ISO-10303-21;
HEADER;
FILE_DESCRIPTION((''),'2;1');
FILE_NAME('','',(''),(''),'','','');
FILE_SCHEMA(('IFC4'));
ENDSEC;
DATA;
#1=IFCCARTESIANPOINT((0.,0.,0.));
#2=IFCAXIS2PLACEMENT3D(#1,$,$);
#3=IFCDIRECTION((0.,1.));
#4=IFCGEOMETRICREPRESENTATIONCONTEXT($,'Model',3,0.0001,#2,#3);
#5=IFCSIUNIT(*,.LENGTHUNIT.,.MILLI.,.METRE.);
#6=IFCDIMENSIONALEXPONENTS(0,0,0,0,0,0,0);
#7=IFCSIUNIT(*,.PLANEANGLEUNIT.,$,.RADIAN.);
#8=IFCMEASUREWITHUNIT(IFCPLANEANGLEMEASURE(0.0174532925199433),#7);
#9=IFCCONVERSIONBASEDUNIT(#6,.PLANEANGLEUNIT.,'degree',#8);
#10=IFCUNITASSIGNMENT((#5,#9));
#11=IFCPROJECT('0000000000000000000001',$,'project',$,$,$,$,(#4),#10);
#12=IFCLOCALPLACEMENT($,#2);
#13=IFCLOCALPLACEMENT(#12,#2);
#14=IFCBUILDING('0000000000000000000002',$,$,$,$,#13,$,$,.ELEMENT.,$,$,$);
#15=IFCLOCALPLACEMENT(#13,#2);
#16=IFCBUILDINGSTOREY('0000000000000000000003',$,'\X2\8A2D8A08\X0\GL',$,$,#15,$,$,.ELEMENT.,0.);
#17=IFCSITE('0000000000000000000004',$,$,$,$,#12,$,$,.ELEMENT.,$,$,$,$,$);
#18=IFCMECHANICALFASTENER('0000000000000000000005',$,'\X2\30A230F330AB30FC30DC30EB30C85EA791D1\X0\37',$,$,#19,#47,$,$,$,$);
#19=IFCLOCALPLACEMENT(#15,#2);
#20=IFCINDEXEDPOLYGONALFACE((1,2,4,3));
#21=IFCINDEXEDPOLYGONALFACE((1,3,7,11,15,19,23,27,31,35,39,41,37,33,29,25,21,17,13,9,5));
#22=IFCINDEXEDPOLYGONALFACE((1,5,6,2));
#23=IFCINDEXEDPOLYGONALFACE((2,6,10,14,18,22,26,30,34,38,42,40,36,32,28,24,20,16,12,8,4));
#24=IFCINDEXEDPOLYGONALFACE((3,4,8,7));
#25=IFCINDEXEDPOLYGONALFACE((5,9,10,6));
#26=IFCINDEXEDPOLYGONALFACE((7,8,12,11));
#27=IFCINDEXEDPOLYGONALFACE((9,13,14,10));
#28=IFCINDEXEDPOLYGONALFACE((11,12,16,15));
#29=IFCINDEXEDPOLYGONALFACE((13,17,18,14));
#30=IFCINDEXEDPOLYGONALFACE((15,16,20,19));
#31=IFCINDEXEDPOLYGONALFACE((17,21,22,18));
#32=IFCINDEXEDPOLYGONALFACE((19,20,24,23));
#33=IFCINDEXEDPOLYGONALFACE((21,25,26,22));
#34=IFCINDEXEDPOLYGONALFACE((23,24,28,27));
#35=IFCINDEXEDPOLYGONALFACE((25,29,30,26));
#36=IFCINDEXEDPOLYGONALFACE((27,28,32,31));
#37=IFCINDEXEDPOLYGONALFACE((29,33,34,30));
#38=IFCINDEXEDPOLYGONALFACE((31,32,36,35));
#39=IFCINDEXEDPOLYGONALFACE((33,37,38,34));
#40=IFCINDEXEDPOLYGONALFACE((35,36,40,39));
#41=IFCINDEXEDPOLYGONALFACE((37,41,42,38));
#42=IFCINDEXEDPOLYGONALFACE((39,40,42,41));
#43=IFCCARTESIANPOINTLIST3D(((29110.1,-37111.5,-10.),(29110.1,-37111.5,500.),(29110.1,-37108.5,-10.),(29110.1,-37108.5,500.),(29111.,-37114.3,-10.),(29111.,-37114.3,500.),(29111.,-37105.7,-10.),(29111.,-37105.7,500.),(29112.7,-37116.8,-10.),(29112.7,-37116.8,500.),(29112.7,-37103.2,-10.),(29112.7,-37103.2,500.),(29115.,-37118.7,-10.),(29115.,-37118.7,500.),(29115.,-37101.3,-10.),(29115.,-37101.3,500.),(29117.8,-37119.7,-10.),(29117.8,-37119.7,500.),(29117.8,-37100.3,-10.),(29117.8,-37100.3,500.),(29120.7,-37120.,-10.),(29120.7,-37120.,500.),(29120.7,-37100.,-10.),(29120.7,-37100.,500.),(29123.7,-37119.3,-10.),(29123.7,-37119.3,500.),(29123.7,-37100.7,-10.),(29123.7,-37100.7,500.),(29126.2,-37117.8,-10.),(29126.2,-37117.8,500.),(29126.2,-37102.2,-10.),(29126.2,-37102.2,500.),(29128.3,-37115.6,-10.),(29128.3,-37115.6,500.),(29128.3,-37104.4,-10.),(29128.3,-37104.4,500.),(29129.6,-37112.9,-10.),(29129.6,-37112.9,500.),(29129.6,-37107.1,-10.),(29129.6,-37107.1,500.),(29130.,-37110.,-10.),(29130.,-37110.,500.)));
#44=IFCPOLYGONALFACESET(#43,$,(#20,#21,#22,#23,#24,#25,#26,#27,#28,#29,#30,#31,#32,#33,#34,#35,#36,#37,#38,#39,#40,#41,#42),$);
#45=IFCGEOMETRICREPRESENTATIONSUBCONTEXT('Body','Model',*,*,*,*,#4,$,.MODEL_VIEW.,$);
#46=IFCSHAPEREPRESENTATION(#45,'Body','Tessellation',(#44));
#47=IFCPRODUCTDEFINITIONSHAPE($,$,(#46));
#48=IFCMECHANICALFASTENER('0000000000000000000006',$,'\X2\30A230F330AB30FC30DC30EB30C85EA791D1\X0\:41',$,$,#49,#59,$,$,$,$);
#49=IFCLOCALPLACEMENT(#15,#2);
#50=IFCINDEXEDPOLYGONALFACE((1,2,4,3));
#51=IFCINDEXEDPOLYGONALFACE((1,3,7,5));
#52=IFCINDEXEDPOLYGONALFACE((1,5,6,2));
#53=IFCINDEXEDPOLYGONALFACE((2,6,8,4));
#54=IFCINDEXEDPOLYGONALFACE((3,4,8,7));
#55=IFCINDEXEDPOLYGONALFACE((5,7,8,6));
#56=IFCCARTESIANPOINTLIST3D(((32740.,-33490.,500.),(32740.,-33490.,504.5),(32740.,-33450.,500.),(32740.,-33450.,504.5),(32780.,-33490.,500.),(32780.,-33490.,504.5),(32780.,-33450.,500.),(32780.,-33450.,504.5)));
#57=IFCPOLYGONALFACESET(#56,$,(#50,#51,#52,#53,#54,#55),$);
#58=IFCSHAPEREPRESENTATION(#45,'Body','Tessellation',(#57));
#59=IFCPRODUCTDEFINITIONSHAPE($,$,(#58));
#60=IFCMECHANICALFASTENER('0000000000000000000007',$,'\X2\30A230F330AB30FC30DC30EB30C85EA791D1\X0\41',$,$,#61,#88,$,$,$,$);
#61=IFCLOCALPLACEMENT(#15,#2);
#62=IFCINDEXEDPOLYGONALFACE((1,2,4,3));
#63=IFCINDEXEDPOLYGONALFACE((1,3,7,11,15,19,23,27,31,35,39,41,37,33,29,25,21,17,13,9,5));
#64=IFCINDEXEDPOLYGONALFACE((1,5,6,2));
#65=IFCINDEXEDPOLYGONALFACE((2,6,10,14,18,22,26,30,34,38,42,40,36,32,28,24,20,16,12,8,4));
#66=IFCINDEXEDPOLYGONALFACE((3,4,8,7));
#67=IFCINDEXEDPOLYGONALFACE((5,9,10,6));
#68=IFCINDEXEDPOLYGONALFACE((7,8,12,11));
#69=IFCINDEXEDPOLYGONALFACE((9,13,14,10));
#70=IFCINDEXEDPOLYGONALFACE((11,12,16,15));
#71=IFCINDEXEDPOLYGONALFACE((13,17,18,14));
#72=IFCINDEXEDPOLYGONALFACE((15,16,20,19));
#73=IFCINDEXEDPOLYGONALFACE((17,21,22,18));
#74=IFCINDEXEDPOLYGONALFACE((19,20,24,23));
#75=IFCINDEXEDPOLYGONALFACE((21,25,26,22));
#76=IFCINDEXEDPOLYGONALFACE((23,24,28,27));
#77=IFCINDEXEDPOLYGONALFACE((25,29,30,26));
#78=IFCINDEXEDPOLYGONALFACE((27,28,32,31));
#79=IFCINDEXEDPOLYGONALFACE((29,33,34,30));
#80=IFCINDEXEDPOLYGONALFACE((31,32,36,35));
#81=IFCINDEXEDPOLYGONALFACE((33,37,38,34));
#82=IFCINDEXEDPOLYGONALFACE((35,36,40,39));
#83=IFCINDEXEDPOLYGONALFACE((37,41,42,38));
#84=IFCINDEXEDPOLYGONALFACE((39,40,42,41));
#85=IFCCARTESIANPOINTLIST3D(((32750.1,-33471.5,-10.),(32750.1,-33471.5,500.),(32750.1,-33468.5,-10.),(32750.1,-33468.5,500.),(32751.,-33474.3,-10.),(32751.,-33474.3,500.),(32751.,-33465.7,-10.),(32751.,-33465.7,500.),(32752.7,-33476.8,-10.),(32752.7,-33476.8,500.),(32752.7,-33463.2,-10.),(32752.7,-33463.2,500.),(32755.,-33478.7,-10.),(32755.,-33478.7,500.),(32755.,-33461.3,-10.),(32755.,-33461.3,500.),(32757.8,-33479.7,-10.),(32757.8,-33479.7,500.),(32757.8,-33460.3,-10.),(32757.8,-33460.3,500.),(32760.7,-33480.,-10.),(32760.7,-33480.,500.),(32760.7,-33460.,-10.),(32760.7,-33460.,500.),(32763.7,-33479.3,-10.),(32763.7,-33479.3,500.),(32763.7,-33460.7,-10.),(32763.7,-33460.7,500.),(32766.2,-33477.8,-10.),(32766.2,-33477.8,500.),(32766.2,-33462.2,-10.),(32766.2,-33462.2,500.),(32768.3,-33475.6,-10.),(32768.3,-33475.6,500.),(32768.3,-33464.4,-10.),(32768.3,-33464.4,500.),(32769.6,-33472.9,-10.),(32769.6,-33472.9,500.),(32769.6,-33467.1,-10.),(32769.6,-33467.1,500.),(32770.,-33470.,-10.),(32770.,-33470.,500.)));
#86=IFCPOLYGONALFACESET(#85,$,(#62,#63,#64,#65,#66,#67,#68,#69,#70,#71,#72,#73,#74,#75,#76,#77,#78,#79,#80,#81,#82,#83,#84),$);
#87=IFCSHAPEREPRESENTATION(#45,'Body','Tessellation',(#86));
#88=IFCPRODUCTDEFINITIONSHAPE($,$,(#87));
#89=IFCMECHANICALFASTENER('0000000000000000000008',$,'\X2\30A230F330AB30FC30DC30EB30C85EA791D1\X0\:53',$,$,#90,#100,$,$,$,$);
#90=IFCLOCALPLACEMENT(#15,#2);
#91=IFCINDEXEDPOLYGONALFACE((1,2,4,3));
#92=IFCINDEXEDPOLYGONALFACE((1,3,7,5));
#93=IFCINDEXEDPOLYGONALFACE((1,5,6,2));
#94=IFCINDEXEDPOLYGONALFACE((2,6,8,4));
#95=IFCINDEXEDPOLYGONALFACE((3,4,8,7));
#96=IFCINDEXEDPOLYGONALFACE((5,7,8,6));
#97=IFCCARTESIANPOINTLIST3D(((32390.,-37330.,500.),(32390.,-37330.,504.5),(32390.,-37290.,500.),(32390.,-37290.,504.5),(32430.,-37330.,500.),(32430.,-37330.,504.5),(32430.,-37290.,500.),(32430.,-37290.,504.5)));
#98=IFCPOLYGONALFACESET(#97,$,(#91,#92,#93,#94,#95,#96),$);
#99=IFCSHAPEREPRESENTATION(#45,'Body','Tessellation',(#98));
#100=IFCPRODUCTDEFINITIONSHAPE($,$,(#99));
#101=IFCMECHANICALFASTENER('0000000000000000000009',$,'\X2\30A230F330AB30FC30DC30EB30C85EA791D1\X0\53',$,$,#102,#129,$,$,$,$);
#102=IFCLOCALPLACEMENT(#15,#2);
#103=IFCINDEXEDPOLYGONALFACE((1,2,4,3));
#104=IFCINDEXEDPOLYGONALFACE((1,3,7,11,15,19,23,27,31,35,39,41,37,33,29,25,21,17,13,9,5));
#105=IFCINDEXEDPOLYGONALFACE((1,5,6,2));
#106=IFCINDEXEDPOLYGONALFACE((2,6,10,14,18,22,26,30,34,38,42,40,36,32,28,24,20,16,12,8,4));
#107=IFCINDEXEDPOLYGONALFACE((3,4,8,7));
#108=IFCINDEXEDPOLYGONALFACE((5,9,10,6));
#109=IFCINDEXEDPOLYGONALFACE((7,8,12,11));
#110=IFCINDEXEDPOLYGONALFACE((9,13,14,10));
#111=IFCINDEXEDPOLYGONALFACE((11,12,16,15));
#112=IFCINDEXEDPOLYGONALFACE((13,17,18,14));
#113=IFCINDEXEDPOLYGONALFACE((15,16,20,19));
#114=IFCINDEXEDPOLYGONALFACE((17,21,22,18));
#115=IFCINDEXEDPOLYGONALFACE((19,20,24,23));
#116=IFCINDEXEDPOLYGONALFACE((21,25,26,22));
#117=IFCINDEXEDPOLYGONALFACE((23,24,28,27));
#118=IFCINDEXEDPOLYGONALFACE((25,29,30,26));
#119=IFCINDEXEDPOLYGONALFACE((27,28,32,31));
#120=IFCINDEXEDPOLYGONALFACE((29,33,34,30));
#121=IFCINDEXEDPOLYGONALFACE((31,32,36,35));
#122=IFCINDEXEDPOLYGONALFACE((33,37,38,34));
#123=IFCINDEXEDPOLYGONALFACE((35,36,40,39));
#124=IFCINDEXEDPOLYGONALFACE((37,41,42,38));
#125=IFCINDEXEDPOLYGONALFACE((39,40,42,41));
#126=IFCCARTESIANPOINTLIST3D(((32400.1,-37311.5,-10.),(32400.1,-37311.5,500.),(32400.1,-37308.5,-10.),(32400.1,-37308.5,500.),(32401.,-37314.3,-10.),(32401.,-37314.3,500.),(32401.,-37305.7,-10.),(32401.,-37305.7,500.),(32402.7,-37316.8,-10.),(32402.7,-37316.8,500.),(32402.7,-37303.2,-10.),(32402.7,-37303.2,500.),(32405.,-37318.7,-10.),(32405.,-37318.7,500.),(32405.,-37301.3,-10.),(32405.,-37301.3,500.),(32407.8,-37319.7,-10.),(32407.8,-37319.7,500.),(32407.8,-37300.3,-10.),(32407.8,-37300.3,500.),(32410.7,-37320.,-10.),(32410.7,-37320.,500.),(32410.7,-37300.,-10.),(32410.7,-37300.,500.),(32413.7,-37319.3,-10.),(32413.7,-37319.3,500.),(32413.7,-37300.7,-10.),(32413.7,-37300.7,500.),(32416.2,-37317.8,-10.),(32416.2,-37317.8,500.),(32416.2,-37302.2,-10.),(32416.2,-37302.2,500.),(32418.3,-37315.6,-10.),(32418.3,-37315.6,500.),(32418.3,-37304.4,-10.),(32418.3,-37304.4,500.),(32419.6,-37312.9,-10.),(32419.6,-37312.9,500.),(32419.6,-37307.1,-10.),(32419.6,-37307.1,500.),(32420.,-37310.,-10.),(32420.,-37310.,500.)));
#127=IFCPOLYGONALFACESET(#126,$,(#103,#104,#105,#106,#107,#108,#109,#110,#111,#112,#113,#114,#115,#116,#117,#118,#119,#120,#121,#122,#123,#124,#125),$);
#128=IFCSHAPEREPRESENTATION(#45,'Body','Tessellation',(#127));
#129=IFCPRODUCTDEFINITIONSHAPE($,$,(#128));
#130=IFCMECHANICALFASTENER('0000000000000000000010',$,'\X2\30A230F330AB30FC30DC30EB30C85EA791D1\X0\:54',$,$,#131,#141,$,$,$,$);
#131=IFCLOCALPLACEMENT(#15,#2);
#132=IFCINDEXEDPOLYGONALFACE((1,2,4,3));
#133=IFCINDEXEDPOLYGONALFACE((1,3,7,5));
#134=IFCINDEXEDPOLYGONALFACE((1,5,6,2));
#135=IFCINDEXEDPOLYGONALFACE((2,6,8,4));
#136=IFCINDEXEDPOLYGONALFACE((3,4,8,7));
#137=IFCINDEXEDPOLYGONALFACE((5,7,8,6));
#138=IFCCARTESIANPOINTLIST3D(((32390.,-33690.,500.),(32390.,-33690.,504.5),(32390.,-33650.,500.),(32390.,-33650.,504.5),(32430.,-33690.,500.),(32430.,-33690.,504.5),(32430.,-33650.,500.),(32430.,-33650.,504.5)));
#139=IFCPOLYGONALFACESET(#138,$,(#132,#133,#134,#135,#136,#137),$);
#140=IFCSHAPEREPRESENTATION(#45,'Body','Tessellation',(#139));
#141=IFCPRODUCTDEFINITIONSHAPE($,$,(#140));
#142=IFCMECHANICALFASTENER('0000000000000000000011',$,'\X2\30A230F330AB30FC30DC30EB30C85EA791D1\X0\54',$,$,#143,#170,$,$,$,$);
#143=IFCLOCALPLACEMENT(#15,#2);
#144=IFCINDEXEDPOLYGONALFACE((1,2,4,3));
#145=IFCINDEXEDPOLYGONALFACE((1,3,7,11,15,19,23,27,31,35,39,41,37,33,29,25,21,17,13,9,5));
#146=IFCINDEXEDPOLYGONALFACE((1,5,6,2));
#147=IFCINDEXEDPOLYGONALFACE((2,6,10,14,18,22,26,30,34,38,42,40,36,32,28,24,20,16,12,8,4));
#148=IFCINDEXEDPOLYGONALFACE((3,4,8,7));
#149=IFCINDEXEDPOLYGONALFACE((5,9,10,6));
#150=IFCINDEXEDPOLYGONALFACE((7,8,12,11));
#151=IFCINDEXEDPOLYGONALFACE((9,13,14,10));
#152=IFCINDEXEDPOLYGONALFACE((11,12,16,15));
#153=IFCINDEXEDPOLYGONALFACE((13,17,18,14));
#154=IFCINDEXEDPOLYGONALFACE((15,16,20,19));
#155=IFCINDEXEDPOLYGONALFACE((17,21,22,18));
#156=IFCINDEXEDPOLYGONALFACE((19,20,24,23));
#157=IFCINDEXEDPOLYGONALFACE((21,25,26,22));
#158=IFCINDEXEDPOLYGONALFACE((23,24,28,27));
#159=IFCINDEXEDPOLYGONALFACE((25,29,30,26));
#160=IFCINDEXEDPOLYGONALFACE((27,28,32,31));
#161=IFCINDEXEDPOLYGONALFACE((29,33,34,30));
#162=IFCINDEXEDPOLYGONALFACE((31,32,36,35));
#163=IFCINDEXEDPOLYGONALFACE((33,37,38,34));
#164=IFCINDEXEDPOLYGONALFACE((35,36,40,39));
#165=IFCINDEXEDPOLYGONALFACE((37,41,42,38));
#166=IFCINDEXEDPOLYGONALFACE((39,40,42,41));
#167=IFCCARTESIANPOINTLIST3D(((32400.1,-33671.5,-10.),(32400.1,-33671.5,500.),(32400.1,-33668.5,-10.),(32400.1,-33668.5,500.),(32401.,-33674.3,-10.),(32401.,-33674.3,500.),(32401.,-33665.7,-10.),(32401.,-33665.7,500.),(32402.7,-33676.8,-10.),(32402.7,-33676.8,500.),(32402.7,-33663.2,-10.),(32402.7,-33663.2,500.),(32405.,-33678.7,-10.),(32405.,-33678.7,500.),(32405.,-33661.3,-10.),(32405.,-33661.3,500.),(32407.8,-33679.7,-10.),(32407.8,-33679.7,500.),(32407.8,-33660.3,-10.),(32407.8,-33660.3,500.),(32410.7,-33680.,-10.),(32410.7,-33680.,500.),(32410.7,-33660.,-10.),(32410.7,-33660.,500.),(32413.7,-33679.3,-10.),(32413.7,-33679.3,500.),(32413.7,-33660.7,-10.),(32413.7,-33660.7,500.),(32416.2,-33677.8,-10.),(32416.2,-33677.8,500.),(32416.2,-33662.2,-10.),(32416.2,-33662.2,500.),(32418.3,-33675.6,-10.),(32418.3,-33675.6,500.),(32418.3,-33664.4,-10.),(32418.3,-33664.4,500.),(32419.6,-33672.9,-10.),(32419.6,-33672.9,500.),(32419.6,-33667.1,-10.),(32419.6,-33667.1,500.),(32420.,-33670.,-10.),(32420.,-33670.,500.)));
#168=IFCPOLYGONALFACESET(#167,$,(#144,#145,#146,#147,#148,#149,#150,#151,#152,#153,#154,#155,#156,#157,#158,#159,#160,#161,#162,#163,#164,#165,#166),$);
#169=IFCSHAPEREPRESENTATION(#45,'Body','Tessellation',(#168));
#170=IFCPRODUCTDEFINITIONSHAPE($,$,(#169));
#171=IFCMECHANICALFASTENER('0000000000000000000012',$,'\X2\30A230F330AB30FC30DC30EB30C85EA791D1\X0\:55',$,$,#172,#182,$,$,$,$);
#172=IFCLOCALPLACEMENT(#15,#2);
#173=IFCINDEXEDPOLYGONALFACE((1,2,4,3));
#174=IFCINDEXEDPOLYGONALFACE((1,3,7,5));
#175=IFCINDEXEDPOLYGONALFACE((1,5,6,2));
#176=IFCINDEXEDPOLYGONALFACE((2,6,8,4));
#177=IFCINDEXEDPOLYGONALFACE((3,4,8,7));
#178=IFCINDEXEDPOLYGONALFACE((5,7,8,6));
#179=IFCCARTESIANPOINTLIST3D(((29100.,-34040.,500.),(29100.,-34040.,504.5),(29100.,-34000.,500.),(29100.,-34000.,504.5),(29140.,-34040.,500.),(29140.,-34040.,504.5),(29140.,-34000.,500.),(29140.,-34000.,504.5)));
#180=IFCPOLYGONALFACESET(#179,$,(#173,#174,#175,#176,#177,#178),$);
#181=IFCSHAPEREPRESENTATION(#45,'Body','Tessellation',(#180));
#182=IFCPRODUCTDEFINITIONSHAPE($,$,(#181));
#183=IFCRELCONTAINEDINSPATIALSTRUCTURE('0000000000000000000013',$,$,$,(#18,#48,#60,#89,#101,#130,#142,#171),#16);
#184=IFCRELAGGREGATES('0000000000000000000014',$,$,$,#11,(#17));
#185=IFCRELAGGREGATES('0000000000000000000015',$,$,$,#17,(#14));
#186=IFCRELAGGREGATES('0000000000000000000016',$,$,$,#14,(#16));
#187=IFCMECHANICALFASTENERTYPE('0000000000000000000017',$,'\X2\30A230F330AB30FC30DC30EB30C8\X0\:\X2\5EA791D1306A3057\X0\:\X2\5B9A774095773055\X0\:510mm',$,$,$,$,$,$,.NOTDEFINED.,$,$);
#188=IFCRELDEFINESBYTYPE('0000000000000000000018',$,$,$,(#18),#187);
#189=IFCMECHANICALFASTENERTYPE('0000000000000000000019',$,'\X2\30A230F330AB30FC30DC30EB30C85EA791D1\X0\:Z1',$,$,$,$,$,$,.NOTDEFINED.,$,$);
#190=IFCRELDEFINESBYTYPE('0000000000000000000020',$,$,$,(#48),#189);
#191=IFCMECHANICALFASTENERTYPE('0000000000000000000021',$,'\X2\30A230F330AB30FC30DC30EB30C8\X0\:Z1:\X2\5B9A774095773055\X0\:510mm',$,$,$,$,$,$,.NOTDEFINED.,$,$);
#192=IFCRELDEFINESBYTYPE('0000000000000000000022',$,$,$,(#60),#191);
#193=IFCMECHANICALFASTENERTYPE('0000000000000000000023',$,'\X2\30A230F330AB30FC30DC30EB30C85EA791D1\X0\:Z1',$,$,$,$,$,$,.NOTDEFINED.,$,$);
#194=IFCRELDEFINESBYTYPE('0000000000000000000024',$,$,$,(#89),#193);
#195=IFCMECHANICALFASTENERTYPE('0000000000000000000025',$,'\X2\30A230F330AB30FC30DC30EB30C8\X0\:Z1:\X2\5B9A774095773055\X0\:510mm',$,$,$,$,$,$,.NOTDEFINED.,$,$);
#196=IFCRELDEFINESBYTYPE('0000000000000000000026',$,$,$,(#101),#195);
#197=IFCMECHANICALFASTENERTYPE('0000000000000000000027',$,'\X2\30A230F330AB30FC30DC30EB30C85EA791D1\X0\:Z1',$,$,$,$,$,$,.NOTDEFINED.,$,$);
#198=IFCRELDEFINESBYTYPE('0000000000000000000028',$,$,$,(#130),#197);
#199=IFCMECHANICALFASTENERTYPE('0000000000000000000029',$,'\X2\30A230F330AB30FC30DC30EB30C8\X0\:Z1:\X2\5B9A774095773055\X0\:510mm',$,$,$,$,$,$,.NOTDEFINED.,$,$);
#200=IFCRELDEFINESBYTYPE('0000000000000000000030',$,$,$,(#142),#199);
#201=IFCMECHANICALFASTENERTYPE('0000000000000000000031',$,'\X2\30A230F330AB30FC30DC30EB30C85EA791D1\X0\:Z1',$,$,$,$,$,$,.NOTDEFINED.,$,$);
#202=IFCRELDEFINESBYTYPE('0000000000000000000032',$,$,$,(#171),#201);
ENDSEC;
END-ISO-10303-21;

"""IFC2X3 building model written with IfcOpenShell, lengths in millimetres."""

from ifc_helpers import new_model, entity, si_unit, converted_unit, direction, frame, origin, origin_with_axes, origin_2d, place, context, subcontext, project, spatial, rectangle, circle, extrude, type_object, element, save


model = new_model("IFC2X3")

# Units and contexts
model_context = context("Model", 3, precision=0.0001, world=origin(), true_north=direction((0.0, 1.0)))
body_context = subcontext(model_context, "Body", "Model", "MODEL_VIEW")
ifc_project = project(units=[si_unit("LENGTHUNIT", "METRE", prefix="MILLI"), converted_unit("PLANEANGLEUNIT", "degree", entity("IfcPlaneAngleMeasure", 0.0174532925199433), si_unit("PLANEANGLEUNIT", "RADIAN"), dimensions=[0, 0, 0, 0, 0, 0, 0])], contexts=[model_context])

# Site, building, storey
site_placement = place(None, origin())
site = spatial("IfcSite", under=ifc_project, at=site_placement, CompositionType="ELEMENT")
building_placement = place(site_placement, origin())
building = spatial("IfcBuilding", under=site, at=building_placement, CompositionType="ELEMENT")
storey_placement = place(building_placement, origin())
storey = spatial("IfcBuildingStorey", under=building, at=storey_placement, Name="設計GL", CompositionType="ELEMENT", Elevation=0.0)

# Mechanical fasteners
mechanical_fastener_type_1 = type_object("IfcMechanicalFastenerType", Name="アンカーボルト:座金なし:定着長さ:510mm")
mechanical_fastener_1_placement = place(storey_placement, frame((29120.0, -37110.0, -10.0)))
element("IfcMechanicalFastener", 1, at=mechanical_fastener_1_placement, inside=storey, type_object=mechanical_fastener_type_1, Name="アンカーボルト座金37", context=body_context, shape_type="SweptSolid", body=[
    extrude(circle(Radius=10.0, at=origin_2d()), origin_with_axes(), (0.0, 0.0, 1.0), 510.0),
])
mechanical_fastener_type_2 = type_object("IfcMechanicalFastenerType", Name="アンカーボルト座金:Z1")
mechanical_fastener_2_placement = place(storey_placement, frame((32760.0, -33470.0, 500.0)))
element("IfcMechanicalFastener", 2, at=mechanical_fastener_2_placement, inside=storey, type_object=mechanical_fastener_type_2, Name="アンカーボルト座金:41", context=body_context, shape_type="SweptSolid", body=[
    extrude(rectangle(XDim=40.0, YDim=40.0, at=origin_2d()), origin_with_axes(), (0.0, 0.0, 1.0), 4.5),
])
mechanical_fastener_type_3 = type_object("IfcMechanicalFastenerType", Name="アンカーボルト:Z1:定着長さ:510mm")
mechanical_fastener_3_placement = place(storey_placement, frame((32760.0, -33470.0, -10.0)))
element("IfcMechanicalFastener", 3, at=mechanical_fastener_3_placement, inside=storey, type_object=mechanical_fastener_type_3, Name="アンカーボルト座金41", context=body_context, shape_type="SweptSolid", body=[
    extrude(circle(Radius=10.0, at=origin_2d()), origin_with_axes(), (0.0, 0.0, 1.0), 510.0),
])
mechanical_fastener_type_4 = type_object("IfcMechanicalFastenerType", Name="アンカーボルト座金:Z1")
mechanical_fastener_4_placement = place(storey_placement, frame((32410.0, -37310.0, 500.0)))
element("IfcMechanicalFastener", 4, at=mechanical_fastener_4_placement, inside=storey, type_object=mechanical_fastener_type_4, Name="アンカーボルト座金:53", context=body_context, shape_type="SweptSolid", body=[
    extrude(rectangle(XDim=40.0, YDim=40.0, at=origin_2d()), origin_with_axes(), (0.0, 0.0, 1.0), 4.5),
])
mechanical_fastener_type_5 = type_object("IfcMechanicalFastenerType", Name="アンカーボルト:Z1:定着長さ:510mm")
mechanical_fastener_5_placement = place(storey_placement, frame((32410.0, -37310.0, -10.0)))
element("IfcMechanicalFastener", 5, at=mechanical_fastener_5_placement, inside=storey, type_object=mechanical_fastener_type_5, Name="アンカーボルト座金53", context=body_context, shape_type="SweptSolid", body=[
    extrude(circle(Radius=10.0, at=origin_2d()), origin_with_axes(), (0.0, 0.0, 1.0), 510.0),
])
mechanical_fastener_type_6 = type_object("IfcMechanicalFastenerType", Name="アンカーボルト座金:Z1")
mechanical_fastener_6_placement = place(storey_placement, frame((32410.0, -33670.0, 500.0)))
element("IfcMechanicalFastener", 6, at=mechanical_fastener_6_placement, inside=storey, type_object=mechanical_fastener_type_6, Name="アンカーボルト座金:54", context=body_context, shape_type="SweptSolid", body=[
    extrude(rectangle(XDim=40.0, YDim=40.0, at=origin_2d()), origin_with_axes(), (0.0, 0.0, 1.0), 4.5),
])
mechanical_fastener_type_7 = type_object("IfcMechanicalFastenerType", Name="アンカーボルト:Z1:定着長さ:510mm")
mechanical_fastener_7_placement = place(storey_placement, frame((32410.0, -33670.0, -10.0)))
element("IfcMechanicalFastener", 7, at=mechanical_fastener_7_placement, inside=storey, type_object=mechanical_fastener_type_7, Name="アンカーボルト座金54", context=body_context, shape_type="SweptSolid", body=[
    extrude(circle(Radius=10.0, at=origin_2d()), origin_with_axes(), (0.0, 0.0, 1.0), 510.0),
])
mechanical_fastener_type_8 = type_object("IfcMechanicalFastenerType", Name="アンカーボルト座金:Z1")
mechanical_fastener_8_placement = place(storey_placement, frame((29120.0, -34020.0, 500.0)))
element("IfcMechanicalFastener", 8, at=mechanical_fastener_8_placement, inside=storey, type_object=mechanical_fastener_type_8, Name="アンカーボルト座金:55", context=body_context, shape_type="SweptSolid", body=[
    extrude(rectangle(XDim=40.0, YDim=40.0, at=origin_2d()), origin_with_axes(), (0.0, 0.0, 1.0), 4.5),
])

save(model, "model.ifc")
